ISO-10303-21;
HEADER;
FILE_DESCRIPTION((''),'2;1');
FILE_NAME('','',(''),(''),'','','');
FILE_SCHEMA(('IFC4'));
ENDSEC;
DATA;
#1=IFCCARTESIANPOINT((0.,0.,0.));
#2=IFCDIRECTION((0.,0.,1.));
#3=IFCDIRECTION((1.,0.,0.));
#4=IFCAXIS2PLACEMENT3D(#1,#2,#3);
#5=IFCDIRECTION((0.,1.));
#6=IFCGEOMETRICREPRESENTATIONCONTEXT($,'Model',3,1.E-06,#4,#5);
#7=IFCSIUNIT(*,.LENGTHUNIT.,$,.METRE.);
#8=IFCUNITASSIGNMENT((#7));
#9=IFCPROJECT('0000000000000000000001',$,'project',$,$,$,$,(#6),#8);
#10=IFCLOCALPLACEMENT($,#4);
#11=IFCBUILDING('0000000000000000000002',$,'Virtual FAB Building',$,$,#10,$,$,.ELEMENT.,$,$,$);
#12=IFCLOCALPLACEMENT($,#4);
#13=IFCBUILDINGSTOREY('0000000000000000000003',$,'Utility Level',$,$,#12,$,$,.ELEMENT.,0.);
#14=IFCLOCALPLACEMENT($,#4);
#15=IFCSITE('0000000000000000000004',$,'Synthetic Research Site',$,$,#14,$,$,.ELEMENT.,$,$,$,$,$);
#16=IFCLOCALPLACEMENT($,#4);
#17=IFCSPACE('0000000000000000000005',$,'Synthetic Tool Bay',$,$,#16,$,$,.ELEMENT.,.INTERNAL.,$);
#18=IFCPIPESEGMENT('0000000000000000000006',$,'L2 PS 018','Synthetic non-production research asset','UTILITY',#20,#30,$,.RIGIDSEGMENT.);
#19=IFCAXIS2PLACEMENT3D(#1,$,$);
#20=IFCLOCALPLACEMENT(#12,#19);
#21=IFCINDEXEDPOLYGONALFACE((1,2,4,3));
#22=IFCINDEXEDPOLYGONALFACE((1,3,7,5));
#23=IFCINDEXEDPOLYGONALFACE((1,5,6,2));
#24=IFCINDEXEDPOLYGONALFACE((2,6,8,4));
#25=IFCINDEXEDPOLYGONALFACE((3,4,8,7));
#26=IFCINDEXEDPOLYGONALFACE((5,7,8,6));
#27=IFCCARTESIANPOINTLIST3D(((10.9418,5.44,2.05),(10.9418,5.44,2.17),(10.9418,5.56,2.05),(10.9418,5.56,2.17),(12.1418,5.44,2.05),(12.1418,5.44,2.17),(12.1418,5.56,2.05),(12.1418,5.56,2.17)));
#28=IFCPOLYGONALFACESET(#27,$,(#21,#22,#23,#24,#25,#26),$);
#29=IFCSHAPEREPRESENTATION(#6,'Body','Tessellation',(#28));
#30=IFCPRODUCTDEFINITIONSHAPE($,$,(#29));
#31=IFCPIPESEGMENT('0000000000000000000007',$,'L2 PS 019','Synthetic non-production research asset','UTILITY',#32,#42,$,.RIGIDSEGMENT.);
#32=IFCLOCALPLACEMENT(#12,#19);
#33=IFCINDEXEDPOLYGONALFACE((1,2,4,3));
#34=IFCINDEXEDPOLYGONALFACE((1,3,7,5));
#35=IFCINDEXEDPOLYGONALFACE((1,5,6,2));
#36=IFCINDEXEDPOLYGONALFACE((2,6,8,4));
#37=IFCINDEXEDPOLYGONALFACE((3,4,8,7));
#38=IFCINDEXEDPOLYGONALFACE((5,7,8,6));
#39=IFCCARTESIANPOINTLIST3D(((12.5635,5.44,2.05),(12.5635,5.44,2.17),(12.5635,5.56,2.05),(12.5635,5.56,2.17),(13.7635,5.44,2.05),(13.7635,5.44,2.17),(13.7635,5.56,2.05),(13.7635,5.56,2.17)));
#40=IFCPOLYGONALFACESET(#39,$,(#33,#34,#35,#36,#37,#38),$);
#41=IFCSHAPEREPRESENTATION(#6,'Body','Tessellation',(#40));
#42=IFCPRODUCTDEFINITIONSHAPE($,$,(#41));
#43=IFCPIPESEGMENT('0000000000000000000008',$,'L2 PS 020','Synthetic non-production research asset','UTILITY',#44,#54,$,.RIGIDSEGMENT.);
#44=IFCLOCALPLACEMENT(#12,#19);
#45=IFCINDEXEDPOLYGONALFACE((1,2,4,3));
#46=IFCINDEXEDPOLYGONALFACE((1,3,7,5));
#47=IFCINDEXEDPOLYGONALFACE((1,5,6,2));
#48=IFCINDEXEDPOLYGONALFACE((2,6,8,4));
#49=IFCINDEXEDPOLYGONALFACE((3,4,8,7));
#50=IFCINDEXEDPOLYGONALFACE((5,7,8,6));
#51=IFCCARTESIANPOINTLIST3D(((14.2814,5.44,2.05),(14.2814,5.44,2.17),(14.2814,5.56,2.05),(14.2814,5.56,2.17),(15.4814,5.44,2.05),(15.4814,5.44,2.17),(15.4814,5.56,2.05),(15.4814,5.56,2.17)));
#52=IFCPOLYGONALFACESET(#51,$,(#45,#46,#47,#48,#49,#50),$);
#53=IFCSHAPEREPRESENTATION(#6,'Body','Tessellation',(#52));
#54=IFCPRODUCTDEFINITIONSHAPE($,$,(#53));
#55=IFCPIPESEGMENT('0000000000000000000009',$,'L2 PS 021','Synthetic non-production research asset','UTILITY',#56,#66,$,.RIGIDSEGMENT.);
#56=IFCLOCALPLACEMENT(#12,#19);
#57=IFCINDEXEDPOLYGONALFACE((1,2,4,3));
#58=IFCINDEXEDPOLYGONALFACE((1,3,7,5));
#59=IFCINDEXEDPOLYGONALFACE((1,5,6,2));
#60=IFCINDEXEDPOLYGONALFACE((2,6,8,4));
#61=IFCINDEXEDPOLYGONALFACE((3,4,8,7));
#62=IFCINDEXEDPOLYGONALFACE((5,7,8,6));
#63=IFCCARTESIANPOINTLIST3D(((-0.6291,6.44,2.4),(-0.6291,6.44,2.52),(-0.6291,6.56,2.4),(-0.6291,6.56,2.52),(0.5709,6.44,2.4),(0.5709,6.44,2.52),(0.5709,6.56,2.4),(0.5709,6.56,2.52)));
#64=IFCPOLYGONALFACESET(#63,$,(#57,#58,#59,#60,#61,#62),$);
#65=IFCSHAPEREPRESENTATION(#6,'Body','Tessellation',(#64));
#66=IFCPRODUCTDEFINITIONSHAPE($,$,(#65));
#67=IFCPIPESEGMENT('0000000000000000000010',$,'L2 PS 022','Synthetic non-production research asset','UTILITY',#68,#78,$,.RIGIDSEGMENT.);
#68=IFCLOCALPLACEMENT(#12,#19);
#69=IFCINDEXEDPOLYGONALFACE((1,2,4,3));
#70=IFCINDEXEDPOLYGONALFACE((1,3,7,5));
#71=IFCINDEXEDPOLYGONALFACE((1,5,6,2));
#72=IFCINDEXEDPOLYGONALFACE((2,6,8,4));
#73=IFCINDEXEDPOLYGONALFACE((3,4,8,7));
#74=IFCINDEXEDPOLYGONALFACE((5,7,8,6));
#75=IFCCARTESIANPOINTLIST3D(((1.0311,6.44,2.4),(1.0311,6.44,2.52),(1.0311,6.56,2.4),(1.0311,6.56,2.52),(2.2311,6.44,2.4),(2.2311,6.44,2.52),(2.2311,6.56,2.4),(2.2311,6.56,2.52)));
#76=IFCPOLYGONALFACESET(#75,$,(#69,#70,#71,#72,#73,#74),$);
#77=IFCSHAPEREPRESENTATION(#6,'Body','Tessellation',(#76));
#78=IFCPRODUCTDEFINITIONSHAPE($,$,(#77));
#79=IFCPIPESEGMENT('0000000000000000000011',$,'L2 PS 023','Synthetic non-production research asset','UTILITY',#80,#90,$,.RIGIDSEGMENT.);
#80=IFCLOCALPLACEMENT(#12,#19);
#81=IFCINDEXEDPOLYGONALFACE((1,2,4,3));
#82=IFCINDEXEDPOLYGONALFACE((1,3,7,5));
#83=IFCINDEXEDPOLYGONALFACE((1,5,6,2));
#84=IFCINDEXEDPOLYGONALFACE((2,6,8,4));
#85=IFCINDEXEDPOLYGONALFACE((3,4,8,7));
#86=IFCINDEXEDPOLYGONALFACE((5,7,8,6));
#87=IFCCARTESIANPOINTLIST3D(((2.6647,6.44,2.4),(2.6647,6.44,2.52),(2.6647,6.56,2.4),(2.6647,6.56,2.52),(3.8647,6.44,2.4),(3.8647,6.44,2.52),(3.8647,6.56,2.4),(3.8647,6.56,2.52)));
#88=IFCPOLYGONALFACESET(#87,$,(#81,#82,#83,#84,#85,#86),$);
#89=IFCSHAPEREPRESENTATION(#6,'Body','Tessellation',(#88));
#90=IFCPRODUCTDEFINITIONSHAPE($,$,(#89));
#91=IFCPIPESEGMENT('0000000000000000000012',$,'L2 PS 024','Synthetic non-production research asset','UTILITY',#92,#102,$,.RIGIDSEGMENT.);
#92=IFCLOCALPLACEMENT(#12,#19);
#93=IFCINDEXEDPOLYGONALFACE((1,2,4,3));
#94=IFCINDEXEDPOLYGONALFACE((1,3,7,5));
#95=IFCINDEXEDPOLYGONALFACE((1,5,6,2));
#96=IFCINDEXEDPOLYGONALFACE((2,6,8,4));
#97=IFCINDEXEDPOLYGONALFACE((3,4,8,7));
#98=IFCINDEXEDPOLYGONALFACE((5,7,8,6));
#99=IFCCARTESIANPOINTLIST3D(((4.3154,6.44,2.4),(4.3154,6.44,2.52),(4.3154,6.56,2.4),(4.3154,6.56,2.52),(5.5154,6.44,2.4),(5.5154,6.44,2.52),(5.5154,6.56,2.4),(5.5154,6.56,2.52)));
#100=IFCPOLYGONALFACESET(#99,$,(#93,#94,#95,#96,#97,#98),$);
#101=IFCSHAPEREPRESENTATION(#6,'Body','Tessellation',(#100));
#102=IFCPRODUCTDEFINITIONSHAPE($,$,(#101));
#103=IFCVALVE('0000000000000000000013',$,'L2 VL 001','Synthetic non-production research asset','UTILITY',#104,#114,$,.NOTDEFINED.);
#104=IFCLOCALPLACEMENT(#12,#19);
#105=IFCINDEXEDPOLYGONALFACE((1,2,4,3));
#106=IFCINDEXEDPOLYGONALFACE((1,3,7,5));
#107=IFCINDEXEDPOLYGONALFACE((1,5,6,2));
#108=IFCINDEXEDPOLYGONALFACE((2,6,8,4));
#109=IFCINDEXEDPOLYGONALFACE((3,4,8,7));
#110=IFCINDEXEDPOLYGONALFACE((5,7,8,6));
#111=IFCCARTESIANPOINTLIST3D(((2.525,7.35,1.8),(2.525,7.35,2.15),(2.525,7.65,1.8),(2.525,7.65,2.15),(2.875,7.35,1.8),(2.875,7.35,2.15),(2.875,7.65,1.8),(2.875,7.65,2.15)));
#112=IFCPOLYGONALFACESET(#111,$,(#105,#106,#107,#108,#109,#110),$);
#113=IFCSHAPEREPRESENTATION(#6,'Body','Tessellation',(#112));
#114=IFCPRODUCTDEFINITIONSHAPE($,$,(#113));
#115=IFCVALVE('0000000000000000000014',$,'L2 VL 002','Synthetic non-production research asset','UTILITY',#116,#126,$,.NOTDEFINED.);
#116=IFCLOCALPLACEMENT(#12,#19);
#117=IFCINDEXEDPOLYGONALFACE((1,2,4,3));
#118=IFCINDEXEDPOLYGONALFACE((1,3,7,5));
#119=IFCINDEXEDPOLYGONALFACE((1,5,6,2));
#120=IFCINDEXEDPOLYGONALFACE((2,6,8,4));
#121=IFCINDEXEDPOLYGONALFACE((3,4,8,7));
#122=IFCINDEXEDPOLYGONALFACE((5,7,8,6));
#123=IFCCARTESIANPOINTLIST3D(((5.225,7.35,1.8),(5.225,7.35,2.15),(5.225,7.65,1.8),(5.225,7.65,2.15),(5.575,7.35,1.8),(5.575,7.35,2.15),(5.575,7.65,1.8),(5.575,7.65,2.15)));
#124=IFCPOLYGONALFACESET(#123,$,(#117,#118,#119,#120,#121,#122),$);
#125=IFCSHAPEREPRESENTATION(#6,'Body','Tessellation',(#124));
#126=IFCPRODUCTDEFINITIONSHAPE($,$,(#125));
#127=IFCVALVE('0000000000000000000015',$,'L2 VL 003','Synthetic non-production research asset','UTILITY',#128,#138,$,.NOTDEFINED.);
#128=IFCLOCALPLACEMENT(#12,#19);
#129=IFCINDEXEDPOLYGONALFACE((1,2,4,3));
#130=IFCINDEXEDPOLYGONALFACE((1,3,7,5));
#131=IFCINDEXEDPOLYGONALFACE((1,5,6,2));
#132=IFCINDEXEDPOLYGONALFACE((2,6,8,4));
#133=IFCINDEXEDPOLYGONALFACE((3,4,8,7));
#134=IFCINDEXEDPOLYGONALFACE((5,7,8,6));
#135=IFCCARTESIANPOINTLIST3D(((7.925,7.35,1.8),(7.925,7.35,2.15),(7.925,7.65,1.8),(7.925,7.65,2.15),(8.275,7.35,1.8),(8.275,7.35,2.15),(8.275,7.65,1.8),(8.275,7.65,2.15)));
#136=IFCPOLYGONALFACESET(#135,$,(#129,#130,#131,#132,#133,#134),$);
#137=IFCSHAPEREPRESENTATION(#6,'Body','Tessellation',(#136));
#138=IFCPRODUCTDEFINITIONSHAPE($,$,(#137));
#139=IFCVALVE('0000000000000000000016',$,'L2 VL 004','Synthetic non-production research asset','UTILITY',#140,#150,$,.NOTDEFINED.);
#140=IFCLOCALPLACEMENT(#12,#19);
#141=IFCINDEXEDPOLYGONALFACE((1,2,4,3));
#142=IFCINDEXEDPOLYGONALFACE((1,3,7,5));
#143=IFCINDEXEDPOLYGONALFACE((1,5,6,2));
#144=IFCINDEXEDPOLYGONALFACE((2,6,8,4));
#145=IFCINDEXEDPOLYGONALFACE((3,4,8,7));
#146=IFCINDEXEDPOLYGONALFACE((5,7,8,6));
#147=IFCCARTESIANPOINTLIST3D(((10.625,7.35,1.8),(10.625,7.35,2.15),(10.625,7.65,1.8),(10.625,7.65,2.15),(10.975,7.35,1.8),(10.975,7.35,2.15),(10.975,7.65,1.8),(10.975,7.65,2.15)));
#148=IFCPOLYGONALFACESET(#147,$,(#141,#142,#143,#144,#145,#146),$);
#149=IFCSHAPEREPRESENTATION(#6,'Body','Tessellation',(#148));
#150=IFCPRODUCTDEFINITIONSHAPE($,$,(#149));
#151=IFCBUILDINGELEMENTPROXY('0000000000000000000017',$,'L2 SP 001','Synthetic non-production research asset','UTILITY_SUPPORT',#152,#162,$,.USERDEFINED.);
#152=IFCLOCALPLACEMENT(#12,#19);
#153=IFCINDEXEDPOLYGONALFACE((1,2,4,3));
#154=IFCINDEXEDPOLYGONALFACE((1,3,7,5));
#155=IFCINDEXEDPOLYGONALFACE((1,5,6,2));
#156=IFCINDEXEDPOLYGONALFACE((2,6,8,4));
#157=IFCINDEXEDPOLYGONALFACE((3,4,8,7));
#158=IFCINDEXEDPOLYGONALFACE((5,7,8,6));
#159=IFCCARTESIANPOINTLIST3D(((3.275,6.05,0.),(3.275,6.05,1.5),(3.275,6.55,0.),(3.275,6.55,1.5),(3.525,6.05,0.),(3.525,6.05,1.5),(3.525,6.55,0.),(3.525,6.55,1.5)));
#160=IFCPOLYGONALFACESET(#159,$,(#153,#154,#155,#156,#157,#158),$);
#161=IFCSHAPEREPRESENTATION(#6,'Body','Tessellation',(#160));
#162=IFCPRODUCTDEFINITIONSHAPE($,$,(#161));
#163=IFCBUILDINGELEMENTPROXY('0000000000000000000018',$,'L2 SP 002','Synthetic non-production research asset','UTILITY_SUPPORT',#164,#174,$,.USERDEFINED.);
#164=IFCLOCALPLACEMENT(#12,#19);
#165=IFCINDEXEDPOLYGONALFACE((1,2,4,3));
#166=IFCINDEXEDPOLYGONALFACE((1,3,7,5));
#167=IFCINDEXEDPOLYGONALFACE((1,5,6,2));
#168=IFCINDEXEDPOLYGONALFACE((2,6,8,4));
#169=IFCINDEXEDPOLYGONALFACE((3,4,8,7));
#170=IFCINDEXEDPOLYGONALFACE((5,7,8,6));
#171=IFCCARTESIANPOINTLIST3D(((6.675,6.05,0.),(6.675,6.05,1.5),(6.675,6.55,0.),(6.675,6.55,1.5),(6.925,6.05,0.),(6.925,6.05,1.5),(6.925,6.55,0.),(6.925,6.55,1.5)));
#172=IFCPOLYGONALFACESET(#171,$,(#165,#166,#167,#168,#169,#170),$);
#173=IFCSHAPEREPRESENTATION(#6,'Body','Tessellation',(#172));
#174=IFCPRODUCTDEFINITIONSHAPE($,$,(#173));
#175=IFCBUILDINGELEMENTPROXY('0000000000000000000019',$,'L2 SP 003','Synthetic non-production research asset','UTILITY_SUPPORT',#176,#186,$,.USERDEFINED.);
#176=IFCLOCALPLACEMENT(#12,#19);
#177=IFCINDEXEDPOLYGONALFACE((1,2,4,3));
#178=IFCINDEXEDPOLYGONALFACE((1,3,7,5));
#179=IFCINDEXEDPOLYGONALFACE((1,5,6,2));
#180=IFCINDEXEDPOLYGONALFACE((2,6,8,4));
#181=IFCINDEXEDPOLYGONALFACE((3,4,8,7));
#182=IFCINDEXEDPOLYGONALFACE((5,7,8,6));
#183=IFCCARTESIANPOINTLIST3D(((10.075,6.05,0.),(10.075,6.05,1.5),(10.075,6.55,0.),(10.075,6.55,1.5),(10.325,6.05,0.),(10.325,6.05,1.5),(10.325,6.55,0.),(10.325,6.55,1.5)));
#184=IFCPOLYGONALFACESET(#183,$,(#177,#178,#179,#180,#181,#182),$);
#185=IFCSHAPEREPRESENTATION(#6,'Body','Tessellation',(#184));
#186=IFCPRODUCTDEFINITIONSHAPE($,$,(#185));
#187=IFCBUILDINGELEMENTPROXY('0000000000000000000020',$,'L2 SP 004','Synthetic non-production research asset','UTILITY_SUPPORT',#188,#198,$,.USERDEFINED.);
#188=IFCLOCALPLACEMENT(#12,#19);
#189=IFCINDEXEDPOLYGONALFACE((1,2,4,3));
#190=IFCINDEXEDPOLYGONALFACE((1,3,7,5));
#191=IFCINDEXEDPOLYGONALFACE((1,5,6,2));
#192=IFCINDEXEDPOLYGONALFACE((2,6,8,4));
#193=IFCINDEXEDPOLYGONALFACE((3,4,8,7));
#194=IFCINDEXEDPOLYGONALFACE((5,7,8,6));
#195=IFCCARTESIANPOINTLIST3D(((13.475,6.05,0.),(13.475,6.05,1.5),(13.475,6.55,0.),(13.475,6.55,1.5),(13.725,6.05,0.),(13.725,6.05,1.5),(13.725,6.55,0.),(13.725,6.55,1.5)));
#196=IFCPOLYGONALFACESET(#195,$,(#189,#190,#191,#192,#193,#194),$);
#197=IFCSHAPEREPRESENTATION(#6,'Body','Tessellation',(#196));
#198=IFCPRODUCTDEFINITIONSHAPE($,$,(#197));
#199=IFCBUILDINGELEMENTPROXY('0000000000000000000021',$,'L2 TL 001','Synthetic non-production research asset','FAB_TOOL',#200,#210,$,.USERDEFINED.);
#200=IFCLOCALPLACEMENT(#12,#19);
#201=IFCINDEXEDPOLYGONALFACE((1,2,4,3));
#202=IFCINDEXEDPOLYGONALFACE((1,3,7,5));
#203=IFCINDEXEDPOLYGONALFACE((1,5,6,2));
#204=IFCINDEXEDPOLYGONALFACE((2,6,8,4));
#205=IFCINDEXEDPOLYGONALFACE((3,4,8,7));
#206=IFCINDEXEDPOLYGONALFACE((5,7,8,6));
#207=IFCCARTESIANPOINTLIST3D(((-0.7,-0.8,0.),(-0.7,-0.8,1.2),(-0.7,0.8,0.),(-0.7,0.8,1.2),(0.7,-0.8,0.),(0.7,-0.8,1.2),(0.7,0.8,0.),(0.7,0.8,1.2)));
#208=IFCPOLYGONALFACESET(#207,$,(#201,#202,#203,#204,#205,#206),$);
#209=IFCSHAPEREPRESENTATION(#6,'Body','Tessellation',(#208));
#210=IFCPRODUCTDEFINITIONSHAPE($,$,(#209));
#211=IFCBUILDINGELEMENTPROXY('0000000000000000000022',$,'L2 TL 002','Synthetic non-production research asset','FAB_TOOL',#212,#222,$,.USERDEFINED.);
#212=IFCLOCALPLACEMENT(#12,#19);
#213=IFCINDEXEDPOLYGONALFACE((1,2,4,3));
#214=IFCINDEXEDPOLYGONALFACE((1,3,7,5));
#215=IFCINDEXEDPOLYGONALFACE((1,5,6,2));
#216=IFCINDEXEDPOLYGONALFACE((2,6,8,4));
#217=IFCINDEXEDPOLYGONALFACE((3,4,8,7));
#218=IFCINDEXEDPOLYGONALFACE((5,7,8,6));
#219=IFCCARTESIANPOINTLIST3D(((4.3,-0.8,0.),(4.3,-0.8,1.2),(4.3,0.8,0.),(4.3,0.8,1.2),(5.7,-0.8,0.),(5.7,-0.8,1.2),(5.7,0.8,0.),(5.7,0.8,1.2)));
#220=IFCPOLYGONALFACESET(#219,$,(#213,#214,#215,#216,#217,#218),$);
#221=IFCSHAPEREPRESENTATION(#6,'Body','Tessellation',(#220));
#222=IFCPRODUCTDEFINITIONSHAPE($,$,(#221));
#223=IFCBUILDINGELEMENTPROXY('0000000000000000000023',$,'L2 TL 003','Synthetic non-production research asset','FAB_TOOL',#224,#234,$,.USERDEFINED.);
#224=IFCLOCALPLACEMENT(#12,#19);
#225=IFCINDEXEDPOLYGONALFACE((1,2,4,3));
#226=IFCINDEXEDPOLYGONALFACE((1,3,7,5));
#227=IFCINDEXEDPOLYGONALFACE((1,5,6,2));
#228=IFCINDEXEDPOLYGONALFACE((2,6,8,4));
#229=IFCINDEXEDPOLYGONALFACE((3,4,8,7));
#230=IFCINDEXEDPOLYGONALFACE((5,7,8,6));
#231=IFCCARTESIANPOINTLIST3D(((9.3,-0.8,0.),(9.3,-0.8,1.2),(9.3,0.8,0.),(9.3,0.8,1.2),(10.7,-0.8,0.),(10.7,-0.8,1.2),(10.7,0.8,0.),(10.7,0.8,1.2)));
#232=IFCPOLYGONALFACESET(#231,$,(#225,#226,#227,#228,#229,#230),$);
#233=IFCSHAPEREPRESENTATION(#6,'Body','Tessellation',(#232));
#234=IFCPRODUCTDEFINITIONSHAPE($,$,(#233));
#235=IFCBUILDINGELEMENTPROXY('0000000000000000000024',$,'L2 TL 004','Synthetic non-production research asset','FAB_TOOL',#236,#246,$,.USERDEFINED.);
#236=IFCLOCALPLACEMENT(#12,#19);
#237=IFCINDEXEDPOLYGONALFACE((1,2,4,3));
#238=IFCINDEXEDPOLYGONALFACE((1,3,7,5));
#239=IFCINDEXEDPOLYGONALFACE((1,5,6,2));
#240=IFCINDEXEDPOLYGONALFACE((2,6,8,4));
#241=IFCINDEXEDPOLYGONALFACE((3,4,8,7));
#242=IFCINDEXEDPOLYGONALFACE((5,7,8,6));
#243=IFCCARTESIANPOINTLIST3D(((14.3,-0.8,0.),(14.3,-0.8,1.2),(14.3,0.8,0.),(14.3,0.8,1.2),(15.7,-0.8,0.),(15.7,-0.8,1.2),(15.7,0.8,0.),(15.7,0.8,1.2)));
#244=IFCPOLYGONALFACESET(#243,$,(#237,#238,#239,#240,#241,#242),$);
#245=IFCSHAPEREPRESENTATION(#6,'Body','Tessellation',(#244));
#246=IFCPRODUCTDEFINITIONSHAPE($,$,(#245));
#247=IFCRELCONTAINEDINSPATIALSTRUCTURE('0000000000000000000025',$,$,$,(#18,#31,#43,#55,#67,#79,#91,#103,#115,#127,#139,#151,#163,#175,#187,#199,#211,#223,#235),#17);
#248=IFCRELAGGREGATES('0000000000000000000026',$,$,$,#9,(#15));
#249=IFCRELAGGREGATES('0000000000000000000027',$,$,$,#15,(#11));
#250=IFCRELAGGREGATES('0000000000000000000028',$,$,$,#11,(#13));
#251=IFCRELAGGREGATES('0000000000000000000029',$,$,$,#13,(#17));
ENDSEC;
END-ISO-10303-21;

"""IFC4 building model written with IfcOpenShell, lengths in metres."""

from ifc_helpers import new_model, si_unit, direction, frame, origin_with_axes, origin_2d_with_axis, place, context, project, spatial, rectangle, extrude, element, save


model = new_model("IFC4")

# Units and contexts
model_context = context("Model", 3, precision=1e-06, world=origin_with_axes(), true_north=direction((0.0, 1.0)))
ifc_project = project(units=[si_unit("LENGTHUNIT", "METRE")], contexts=[model_context])

# Site, building, storey, space
site_placement = place(None, origin_with_axes())
site = spatial("IfcSite", under=ifc_project, at=site_placement, Name="Synthetic Research Site", CompositionType="ELEMENT")
building_placement = place(None, origin_with_axes())
building = spatial("IfcBuilding", under=site, at=building_placement, Name="Virtual FAB Building", CompositionType="ELEMENT")
storey_placement = place(None, origin_with_axes())
storey = spatial("IfcBuildingStorey", under=building, at=storey_placement, Name="Utility Level", CompositionType="ELEMENT", Elevation=0.0)
space_placement = place(None, origin_with_axes())
space = spatial("IfcSpace", under=storey, at=space_placement, Name="Synthetic Tool Bay", CompositionType="ELEMENT", PredefinedType="INTERNAL")

# Pipe segments
for number, where, z_axis, x_axis, name in (
    (1, (11.5418, 5.5, 2.05), (0.0, 0.0, 1.0), (1.0, 0.0, 0.0), "L2 PS 018"),
    (2, (13.1635, 5.5, 2.05), (0.0, 0.0, 1.0), (1.0, 0.0, 0.0), "L2 PS 019"),
    (3, (14.8814, 5.5, 2.05), (0.0, 0.0, 1.0), (1.0, 0.0, 0.0), "L2 PS 020"),
    (4, (-0.0291, 6.5, 2.4), (0.0, 0.0, 1.0), (1.0, 0.0, 0.0), "L2 PS 021"),
    (5, (1.6311, 6.5, 2.4), (0.0, 0.0, 1.0), (1.0, 0.0, 0.0), "L2 PS 022"),
    (6, (3.2647, 6.5, 2.4), (0.0, 0.0, 1.0), (1.0, 0.0, 0.0), "L2 PS 023"),
    (7, (4.9154, 6.5, 2.4), (0.0, 0.0, 1.0), (1.0, 0.0, 0.0), "L2 PS 024"),
):
    element("IfcPipeSegment", number, at=place(None, frame(where, z_axis=z_axis, x_axis=x_axis)), inside=space, Name=name, Description="Synthetic non-production research asset", ObjectType="UTILITY", PredefinedType="RIGIDSEGMENT", context=model_context, shape_type="SweptSolid", body=[
        extrude(rectangle(XDim=1.2, YDim=0.12, at=origin_2d_with_axis()), origin_with_axes(), (0.0, 0.0, 1.0), 0.12),
    ])

# Valves
for number, where, z_axis, x_axis, name in (
    (8, (2.7, 7.5, 1.8), (0.0, 0.0, 1.0), (1.0, 0.0, 0.0), "L2 VL 001"),
    (9, (5.4, 7.5, 1.8), (0.0, 0.0, 1.0), (1.0, 0.0, 0.0), "L2 VL 002"),
    (10, (8.1, 7.5, 1.8), (0.0, 0.0, 1.0), (1.0, 0.0, 0.0), "L2 VL 003"),
    (11, (10.8, 7.5, 1.8), (0.0, 0.0, 1.0), (1.0, 0.0, 0.0), "L2 VL 004"),
):
    element("IfcValve", number, at=place(None, frame(where, z_axis=z_axis, x_axis=x_axis)), inside=space, Name=name, Description="Synthetic non-production research asset", ObjectType="UTILITY", PredefinedType="NOTDEFINED", context=model_context, shape_type="SweptSolid", body=[
        extrude(rectangle(XDim=0.35, YDim=0.3, at=origin_2d_with_axis()), origin_with_axes(), (0.0, 0.0, 1.0), 0.35),
    ])

# Building element proxies
for number, where, z_axis, x_axis, name in (
    (12, (3.4, 6.3, 0.0), (0.0, 0.0, 1.0), (1.0, 0.0, 0.0), "L2 SP 001"),
    (13, (6.8, 6.3, 0.0), (0.0, 0.0, 1.0), (1.0, 0.0, 0.0), "L2 SP 002"),
    (14, (10.2, 6.3, 0.0), (0.0, 0.0, 1.0), (1.0, 0.0, 0.0), "L2 SP 003"),
    (15, (13.6, 6.3, 0.0), (0.0, 0.0, 1.0), (1.0, 0.0, 0.0), "L2 SP 004"),
):
    element("IfcBuildingElementProxy", number, at=place(None, frame(where, z_axis=z_axis, x_axis=x_axis)), inside=space, Name=name, Description="Synthetic non-production research asset", ObjectType="UTILITY_SUPPORT", PredefinedType="USERDEFINED", context=model_context, shape_type="SweptSolid", body=[
        extrude(rectangle(XDim=0.25, YDim=0.5, at=origin_2d_with_axis()), origin_with_axes(), (0.0, 0.0, 1.0), 1.5),
    ])
for number, where, z_axis, x_axis, name in (
    (16, (0.0, 0.0, 0.0), (0.0, 0.0, 1.0), (1.0, 0.0, 0.0), "L2 TL 001"),
    (17, (5.0, 0.0, 0.0), (0.0, 0.0, 1.0), (1.0, 0.0, 0.0), "L2 TL 002"),
    (18, (10.0, 0.0, 0.0), (0.0, 0.0, 1.0), (1.0, 0.0, 0.0), "L2 TL 003"),
    (19, (15.0, 0.0, 0.0), (0.0, 0.0, 1.0), (1.0, 0.0, 0.0), "L2 TL 004"),
):
    element("IfcBuildingElementProxy", number, at=place(None, frame(where, z_axis=z_axis, x_axis=x_axis)), inside=space, Name=name, Description="Synthetic non-production research asset", ObjectType="FAB_TOOL", PredefinedType="USERDEFINED", context=model_context, shape_type="SweptSolid", body=[
        extrude(rectangle(XDim=1.4, YDim=1.6, at=origin_2d_with_axis()), origin_with_axes(), (0.0, 0.0, 1.0), 1.2),
    ])

save(model, "model.ifc")
